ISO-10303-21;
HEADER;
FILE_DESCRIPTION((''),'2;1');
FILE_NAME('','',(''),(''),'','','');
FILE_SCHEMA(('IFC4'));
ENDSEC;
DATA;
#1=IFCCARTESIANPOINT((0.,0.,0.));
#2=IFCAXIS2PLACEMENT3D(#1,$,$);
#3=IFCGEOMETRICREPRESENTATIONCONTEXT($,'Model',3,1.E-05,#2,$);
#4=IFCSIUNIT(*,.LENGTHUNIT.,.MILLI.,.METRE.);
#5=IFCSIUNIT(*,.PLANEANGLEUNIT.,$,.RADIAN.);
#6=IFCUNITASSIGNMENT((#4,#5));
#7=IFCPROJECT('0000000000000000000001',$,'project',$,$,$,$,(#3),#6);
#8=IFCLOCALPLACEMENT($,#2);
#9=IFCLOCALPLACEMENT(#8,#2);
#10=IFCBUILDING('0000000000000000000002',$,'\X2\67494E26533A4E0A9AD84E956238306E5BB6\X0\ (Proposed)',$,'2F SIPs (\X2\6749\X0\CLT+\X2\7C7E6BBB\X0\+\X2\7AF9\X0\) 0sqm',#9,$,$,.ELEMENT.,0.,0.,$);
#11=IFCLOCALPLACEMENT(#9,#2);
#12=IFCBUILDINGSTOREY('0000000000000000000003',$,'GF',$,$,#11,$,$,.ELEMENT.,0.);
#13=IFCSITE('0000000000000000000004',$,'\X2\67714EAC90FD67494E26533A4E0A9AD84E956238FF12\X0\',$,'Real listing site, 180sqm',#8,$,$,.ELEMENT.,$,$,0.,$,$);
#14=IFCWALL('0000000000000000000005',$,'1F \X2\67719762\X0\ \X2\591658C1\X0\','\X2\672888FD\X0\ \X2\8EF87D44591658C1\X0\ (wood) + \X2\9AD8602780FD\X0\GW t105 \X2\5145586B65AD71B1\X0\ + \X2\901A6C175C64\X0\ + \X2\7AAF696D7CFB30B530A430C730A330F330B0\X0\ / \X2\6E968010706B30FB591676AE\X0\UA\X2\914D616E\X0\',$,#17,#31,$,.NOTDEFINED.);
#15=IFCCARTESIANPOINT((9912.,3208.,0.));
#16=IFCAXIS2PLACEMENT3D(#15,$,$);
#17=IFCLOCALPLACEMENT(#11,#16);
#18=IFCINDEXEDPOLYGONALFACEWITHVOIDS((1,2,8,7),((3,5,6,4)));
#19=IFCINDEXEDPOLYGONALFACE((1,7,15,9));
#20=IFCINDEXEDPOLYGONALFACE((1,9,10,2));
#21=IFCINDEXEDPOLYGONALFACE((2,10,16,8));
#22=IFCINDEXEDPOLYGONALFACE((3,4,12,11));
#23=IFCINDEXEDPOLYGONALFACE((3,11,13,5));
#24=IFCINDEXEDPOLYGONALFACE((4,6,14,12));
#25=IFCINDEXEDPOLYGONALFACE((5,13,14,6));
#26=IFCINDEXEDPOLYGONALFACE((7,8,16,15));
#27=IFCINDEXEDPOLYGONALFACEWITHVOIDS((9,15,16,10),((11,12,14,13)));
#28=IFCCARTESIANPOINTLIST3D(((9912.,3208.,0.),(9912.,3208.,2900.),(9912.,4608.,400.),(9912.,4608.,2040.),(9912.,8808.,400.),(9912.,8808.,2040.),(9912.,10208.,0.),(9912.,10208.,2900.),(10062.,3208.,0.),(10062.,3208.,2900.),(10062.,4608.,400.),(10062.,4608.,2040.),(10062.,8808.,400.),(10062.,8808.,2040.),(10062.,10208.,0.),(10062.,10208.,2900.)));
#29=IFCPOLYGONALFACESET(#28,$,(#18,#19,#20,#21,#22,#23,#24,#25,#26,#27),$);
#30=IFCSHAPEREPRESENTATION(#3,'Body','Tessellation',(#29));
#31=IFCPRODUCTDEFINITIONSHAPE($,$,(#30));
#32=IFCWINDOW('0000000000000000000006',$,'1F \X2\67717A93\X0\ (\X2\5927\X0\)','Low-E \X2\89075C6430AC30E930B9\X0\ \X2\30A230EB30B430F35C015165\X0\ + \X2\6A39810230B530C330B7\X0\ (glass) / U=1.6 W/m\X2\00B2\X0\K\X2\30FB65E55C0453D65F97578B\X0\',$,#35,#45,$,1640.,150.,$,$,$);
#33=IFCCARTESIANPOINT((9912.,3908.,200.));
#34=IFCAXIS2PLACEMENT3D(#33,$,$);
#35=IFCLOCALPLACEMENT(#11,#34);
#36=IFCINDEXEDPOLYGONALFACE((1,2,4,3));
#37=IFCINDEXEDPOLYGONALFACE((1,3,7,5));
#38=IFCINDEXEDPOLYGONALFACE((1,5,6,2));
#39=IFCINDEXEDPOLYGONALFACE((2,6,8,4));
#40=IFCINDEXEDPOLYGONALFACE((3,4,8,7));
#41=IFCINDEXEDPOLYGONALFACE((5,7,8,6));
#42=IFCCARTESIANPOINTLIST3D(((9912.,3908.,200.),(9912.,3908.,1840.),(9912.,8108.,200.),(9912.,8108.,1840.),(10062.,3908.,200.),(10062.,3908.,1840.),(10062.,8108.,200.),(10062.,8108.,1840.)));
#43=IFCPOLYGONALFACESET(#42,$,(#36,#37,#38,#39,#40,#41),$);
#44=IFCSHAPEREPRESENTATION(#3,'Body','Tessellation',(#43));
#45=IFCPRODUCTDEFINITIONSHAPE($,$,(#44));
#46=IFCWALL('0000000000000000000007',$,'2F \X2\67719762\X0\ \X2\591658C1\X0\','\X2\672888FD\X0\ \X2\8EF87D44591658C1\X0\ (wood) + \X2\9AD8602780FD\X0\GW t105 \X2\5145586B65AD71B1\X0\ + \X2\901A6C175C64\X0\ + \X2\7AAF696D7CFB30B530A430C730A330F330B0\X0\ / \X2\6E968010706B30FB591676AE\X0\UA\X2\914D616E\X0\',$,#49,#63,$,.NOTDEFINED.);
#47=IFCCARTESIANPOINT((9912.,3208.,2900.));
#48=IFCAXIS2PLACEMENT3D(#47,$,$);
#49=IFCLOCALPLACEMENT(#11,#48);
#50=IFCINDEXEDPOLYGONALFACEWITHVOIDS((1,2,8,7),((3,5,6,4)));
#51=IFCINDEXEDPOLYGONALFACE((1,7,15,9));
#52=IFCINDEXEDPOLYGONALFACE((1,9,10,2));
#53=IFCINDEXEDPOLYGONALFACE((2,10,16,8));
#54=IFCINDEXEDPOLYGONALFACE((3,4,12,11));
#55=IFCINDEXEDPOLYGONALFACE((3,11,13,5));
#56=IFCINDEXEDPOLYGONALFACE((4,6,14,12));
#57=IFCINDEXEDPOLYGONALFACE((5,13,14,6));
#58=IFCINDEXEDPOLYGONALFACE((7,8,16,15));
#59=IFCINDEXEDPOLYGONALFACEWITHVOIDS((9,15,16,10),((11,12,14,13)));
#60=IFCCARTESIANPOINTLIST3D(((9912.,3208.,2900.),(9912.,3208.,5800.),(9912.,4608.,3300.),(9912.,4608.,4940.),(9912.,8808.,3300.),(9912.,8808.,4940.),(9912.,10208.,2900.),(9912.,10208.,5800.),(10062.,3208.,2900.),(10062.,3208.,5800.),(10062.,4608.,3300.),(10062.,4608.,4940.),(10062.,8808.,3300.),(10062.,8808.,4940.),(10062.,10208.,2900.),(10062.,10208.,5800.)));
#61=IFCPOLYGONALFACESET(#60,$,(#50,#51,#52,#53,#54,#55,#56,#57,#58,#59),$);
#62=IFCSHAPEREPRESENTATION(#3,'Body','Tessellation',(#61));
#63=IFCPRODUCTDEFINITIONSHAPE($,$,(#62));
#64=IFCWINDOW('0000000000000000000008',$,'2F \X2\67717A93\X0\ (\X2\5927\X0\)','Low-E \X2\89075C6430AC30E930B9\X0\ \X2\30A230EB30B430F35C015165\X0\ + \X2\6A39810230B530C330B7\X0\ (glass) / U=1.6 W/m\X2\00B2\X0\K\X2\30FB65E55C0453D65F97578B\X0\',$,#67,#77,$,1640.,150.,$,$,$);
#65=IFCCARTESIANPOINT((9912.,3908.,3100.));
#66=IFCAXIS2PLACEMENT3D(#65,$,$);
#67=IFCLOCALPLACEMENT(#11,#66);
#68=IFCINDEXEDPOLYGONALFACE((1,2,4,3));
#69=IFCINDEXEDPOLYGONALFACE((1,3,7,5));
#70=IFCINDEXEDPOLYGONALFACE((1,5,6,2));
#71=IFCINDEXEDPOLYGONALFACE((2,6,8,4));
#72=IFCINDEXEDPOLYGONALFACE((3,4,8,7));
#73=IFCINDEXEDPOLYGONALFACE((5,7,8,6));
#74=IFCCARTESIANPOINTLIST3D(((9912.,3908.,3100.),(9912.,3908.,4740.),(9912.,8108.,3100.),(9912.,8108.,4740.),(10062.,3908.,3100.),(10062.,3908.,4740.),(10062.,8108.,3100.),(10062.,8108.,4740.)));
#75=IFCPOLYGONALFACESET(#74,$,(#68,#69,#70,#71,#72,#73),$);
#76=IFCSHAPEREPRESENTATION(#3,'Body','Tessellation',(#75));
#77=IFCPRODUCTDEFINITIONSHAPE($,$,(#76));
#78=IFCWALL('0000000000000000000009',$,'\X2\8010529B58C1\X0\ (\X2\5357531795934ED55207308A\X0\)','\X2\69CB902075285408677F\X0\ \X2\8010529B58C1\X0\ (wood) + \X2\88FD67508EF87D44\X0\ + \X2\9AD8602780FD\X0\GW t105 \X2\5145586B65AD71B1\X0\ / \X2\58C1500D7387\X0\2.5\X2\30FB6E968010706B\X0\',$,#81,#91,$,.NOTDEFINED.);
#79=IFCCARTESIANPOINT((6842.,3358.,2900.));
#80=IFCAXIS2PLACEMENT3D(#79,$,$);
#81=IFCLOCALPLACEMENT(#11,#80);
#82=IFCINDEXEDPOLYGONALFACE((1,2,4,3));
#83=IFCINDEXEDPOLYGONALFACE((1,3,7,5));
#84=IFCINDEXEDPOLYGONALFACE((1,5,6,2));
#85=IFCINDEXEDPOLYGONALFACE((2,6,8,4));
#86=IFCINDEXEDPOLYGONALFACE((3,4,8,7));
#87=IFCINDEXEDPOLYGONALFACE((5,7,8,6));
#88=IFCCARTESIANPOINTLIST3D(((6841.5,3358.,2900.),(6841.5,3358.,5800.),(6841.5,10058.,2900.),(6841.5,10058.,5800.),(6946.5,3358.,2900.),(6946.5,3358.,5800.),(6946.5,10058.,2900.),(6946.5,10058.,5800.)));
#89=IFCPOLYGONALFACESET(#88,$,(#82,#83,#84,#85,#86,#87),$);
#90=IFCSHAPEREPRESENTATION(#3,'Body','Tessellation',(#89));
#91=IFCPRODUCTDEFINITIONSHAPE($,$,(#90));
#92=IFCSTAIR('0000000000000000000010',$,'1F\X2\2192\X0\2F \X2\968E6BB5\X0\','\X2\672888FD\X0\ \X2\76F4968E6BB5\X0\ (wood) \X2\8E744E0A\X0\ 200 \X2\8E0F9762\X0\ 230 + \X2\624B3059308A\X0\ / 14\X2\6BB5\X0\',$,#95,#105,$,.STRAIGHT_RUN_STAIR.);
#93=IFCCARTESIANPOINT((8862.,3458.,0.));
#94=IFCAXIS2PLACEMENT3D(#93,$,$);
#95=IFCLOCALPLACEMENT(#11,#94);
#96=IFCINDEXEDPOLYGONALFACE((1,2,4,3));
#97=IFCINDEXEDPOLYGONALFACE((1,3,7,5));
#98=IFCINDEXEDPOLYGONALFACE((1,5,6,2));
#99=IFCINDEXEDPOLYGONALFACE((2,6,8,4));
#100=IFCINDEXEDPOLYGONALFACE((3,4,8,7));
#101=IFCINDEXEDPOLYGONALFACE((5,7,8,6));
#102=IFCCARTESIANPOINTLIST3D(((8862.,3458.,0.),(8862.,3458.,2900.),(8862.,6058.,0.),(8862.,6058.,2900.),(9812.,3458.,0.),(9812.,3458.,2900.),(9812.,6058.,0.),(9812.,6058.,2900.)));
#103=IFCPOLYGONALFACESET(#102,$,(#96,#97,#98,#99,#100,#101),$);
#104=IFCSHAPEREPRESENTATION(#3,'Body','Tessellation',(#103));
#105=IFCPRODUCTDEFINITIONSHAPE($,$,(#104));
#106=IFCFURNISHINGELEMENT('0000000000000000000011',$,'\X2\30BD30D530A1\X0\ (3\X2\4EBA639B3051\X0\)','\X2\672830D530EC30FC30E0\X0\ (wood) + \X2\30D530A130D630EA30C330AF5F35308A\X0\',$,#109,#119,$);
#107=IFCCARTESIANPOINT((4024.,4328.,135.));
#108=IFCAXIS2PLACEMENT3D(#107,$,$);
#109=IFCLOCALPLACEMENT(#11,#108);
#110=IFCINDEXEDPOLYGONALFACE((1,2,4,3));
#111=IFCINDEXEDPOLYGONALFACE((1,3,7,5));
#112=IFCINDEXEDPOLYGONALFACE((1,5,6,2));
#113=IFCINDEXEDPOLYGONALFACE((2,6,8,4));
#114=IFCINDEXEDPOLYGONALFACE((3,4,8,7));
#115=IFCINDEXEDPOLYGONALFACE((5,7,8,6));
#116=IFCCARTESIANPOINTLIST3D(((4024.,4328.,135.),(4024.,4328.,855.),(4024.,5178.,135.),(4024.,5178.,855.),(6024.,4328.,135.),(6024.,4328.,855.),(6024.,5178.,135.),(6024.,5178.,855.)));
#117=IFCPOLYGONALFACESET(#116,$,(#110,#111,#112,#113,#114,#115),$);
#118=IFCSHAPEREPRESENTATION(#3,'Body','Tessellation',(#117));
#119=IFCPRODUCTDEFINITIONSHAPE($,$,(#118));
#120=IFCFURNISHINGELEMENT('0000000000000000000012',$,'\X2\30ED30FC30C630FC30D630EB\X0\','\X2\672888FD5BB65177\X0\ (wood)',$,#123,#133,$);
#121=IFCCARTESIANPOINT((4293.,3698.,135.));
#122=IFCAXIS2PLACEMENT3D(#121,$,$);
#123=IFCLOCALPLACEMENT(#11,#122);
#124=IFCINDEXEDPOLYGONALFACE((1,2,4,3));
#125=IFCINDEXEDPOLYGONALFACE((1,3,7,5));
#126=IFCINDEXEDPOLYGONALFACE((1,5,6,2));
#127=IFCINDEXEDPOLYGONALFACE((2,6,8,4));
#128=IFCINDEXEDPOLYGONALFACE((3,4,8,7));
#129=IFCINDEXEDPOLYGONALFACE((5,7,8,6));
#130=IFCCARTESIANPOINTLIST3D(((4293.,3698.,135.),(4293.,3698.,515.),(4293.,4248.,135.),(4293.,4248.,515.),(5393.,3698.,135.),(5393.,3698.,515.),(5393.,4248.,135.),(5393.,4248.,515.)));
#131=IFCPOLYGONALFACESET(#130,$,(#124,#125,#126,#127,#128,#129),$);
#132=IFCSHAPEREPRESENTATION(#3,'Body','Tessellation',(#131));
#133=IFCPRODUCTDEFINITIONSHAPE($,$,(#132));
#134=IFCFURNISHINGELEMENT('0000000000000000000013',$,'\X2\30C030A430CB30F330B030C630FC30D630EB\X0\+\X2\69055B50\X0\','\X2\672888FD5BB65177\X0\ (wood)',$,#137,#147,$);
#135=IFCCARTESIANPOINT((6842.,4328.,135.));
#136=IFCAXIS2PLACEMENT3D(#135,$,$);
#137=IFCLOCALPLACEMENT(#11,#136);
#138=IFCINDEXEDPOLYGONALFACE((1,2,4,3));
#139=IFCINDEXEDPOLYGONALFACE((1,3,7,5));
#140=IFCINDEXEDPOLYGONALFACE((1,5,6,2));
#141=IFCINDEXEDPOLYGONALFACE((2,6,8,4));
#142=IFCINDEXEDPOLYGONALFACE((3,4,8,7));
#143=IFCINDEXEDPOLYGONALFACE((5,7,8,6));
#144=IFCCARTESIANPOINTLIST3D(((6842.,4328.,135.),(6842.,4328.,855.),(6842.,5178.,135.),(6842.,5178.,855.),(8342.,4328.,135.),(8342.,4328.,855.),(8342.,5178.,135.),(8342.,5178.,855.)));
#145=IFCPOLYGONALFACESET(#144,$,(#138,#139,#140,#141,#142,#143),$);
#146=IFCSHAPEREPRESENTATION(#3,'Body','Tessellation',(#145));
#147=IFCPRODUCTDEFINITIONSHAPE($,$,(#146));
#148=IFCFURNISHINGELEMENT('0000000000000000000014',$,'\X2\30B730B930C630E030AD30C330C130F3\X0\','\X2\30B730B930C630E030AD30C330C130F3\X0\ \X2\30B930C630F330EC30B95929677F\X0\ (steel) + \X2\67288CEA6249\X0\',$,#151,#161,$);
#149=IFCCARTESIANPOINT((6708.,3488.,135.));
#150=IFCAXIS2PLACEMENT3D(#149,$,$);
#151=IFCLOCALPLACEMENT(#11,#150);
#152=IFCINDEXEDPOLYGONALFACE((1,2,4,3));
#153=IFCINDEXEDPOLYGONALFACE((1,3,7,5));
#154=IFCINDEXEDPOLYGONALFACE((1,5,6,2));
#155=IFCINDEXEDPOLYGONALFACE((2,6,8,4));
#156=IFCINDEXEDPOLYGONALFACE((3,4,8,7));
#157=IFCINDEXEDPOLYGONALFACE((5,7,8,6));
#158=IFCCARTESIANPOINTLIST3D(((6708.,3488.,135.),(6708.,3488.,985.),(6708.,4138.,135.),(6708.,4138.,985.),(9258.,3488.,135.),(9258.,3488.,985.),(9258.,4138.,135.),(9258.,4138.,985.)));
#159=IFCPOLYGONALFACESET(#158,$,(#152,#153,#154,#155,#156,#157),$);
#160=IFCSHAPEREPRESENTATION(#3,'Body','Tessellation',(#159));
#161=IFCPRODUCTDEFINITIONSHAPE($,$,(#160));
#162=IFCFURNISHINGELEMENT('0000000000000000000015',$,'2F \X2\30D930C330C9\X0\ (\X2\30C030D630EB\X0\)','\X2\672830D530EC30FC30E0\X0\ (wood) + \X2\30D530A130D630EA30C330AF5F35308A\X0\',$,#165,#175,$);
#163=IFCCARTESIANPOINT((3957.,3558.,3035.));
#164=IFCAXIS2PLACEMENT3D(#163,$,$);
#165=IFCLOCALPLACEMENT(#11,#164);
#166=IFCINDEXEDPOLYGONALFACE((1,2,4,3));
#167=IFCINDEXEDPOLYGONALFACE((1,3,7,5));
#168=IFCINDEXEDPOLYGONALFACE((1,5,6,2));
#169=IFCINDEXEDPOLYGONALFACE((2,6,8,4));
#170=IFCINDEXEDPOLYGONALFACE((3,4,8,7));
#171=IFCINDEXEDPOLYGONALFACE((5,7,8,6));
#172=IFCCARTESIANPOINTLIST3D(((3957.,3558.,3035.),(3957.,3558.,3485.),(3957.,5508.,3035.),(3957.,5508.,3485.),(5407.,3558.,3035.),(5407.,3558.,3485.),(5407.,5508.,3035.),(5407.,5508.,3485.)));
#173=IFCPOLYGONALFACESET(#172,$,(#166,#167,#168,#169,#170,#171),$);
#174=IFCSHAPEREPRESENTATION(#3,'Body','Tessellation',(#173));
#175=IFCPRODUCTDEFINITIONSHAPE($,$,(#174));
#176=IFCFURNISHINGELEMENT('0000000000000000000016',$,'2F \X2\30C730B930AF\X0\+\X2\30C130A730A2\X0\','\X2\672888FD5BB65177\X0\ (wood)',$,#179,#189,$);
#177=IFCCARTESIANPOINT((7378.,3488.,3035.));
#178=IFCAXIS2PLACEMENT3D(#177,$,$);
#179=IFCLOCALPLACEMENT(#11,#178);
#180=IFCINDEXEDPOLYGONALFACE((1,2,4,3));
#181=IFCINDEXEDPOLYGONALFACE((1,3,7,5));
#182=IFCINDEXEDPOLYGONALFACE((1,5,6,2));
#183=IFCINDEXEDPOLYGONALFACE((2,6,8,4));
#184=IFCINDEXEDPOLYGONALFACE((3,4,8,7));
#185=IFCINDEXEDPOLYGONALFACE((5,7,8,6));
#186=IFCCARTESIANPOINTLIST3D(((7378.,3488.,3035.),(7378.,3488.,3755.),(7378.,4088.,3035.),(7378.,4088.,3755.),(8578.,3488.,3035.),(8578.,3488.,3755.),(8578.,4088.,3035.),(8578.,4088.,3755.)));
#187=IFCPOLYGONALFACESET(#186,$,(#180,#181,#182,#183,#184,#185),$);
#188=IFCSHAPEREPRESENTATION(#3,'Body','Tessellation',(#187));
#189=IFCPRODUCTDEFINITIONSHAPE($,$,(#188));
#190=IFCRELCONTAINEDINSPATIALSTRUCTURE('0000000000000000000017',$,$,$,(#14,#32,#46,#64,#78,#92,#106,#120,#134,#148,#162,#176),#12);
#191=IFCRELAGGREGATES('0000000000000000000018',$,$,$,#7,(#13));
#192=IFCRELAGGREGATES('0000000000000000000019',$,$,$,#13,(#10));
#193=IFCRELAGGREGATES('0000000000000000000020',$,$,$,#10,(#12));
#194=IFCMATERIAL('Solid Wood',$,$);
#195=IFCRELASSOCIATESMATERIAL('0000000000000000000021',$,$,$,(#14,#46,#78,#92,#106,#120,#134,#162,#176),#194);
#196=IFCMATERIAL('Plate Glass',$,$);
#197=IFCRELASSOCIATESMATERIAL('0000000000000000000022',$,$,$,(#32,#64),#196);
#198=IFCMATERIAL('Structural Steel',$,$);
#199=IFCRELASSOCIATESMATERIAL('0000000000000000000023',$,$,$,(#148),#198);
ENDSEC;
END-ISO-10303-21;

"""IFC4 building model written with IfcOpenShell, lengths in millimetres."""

from ifc_helpers import new_model, si_unit, frame, frame_2d, origin, place, context, project, spatial, rectangle, extrude, material, element, fill, save


model = new_model("IFC4")

# Units and contexts
model_context = context("Model", 3, precision=1e-05, world=origin())
ifc_project = project(units=[si_unit("LENGTHUNIT", "METRE", prefix="MILLI"), si_unit("PLANEANGLEUNIT", "RADIAN")], contexts=[model_context])

# Site, building, storey
site_placement = place(None, origin())
site = spatial("IfcSite", under=ifc_project, at=site_placement, Name="東京都杉並区上高井戸２", ObjectType="Real listing site, 180sqm", CompositionType="ELEMENT", RefElevation=0.0)
building_placement = place(site_placement, origin())
building = spatial("IfcBuilding", under=site, at=building_placement, Name="杉並区上高井戸の家 (Proposed)", ObjectType="2F SIPs (杉CLT+籾殻+竹) 0sqm", CompositionType="ELEMENT", ElevationOfRefHeight=0.0, ElevationOfTerrain=0.0)
storey_placement = place(building_placement, origin())
storey = spatial("IfcBuildingStorey", under=building, at=storey_placement, Name="GF", CompositionType="ELEMENT", Elevation=0.0)

# Wall, opening, window
ifc_material_1 = material(Name="Solid Wood")
wall_1_placement = place(storey_placement, frame((9912.0, 3208.0, 0.0)))
wall_1 = element("IfcWall", 1, at=wall_1_placement, inside=storey, material=ifc_material_1, Name="1F 東面 外壁", Description="木製 軸組外壁 (wood) + 高性能GW t105 充填断熱 + 通気層 + 窯業系サイディング / 準耐火・外皮UA配慮", PredefinedType="NOTDEFINED", context=model_context, shape_type="SweptSolid", body=[
    extrude(rectangle(XDim=150.0, YDim=7000.0, at=frame_2d((75.0, 3500.0))), frame((9912.0, 3208.0, 0.0)), (0.0, 0.0, 1.0), 2900.0),
])
opening_1_placement = place(storey_placement, frame((9912.0, 3908.0, 200.0)))
opening_1 = element("IfcOpeningElement", 2, at=opening_1_placement, cuts=wall_1, PredefinedType="NOTDEFINED", context=model_context, shape_type="SweptSolid", body=[
    extrude(rectangle(XDim=150.0, YDim=4200.0, at=frame_2d((75.0, 2100.0))), frame((9912.0, 3908.0, 200.0)), (0.0, 0.0, 1.0), 1640.0),
])
ifc_material_2 = material(Name="Plate Glass")
window_1_placement = place(storey_placement, frame((9912.0, 3908.0, 200.0)))
window_1 = element("IfcWindow", 3, at=window_1_placement, inside=storey, material=ifc_material_2, Name="1F 東窓 (大)", Description="Low-E 複層ガラス アルゴン封入 + 樹脂サッシ (glass) / U=1.6 W/m²K・日射取得型", OverallHeight=1640.0, OverallWidth=150.0, context=model_context, shape_type="SweptSolid", body=[
    extrude(rectangle(XDim=150.0, YDim=4200.0, at=frame_2d((75.0, 2100.0))), frame((9912.0, 3908.0, 200.0)), (0.0, 0.0, 1.0), 1640.0),
])
fill(opening_1, window_1)

# Wall, opening, window
wall_2_placement = place(storey_placement, frame((9912.0, 3208.0, 2900.0)))
wall_2 = element("IfcWall", 4, at=wall_2_placement, inside=storey, material=ifc_material_1, Name="2F 東面 外壁", Description="木製 軸組外壁 (wood) + 高性能GW t105 充填断熱 + 通気層 + 窯業系サイディング / 準耐火・外皮UA配慮", PredefinedType="NOTDEFINED", context=model_context, shape_type="SweptSolid", body=[
    extrude(rectangle(XDim=150.0, YDim=7000.0, at=frame_2d((75.0, 3500.0))), frame((9912.0, 3208.0, 2900.0)), (0.0, 0.0, 1.0), 2900.0),
])
opening_2_placement = place(storey_placement, frame((9912.0, 3908.0, 3100.0)))
opening_2 = element("IfcOpeningElement", 5, at=opening_2_placement, cuts=wall_2, PredefinedType="NOTDEFINED", context=model_context, shape_type="SweptSolid", body=[
    extrude(rectangle(XDim=150.0, YDim=4200.0, at=frame_2d((75.0, 2100.0))), frame((9912.0, 3908.0, 3100.0)), (0.0, 0.0, 1.0), 1640.0),
])
window_2_placement = place(storey_placement, frame((9912.0, 3908.0, 3100.0)))
window_2 = element("IfcWindow", 6, at=window_2_placement, inside=storey, material=ifc_material_2, Name="2F 東窓 (大)", Description="Low-E 複層ガラス アルゴン封入 + 樹脂サッシ (glass) / U=1.6 W/m²K・日射取得型", OverallHeight=1640.0, OverallWidth=150.0, context=model_context, shape_type="SweptSolid", body=[
    extrude(rectangle(XDim=150.0, YDim=4200.0, at=frame_2d((75.0, 2100.0))), frame((9912.0, 3908.0, 3100.0)), (0.0, 0.0, 1.0), 1640.0),
])
fill(opening_2, window_2)

# Wall
wall_3_placement = place(storey_placement, frame((6842.0, 3358.0, 2900.0)))
element("IfcWall", 7, at=wall_3_placement, inside=storey, material=ifc_material_1, Name="耐力壁 (南北間仕切り)", Description="構造用合板 耐力壁 (wood) + 製材軸組 + 高性能GW t105 充填断熱 / 壁倍率2.5・準耐火", PredefinedType="NOTDEFINED", context=model_context, shape_type="SweptSolid", body=[
    extrude(rectangle(XDim=105.0, YDim=6700.0, at=frame_2d((52.0, 3350.0))), frame((6842.0, 3358.0, 2900.0)), (0.0, 0.0, 1.0), 2900.0),
])

# Stair
stair_placement = place(storey_placement, frame((8862.0, 3458.0, 0.0)))
element("IfcStair", 8, at=stair_placement, inside=storey, material=ifc_material_1, Name="1F→2F 階段", Description="木製 直階段 (wood) 蹴上 200 踏面 230 + 手すり / 14段", PredefinedType="STRAIGHT_RUN_STAIR", context=model_context, shape_type="SweptSolid", body=[
    extrude(rectangle(XDim=950.0, YDim=2600.0, at=frame_2d((475.0, 1300.0))), frame((8862.0, 3458.0, 0.0)), (0.0, 0.0, 1.0), 2900.0),
])

# Furnishing elements
furnishing_1_placement = place(storey_placement, frame((4024.0, 4328.0, 135.0)))
element("IfcFurnishingElement", 9, at=furnishing_1_placement, inside=storey, material=ifc_material_1, Name="ソファ (3人掛け)", Description="木フレーム (wood) + ファブリック張り", context=model_context, shape_type="SweptSolid", body=[
    extrude(rectangle(XDim=2000.0, YDim=850.0, at=frame_2d((1000.0, 425.0))), frame((4024.0, 4328.0, 135.0)), (0.0, 0.0, 1.0), 720.0),
])
furnishing_2_placement = place(storey_placement, frame((4293.0, 3698.0, 135.0)))
element("IfcFurnishingElement", 10, at=furnishing_2_placement, inside=storey, material=ifc_material_1, Name="ローテーブル", Description="木製家具 (wood)", context=model_context, shape_type="SweptSolid", body=[
    extrude(rectangle(XDim=1100.0, YDim=550.0, at=frame_2d((550.0, 275.0))), frame((4293.0, 3698.0, 135.0)), (0.0, 0.0, 1.0), 380.0),
])
furnishing_3_placement = place(storey_placement, frame((6842.0, 4328.0, 135.0)))
element("IfcFurnishingElement", 11, at=furnishing_3_placement, inside=storey, material=ifc_material_1, Name="ダイニングテーブル+椅子", Description="木製家具 (wood)", context=model_context, shape_type="SweptSolid", body=[
    extrude(rectangle(XDim=1500.0, YDim=850.0, at=frame_2d((750.0, 425.0))), frame((6842.0, 4328.0, 135.0)), (0.0, 0.0, 1.0), 720.0),
])
ifc_material_3 = material(Name="Structural Steel")
furnishing_4_placement = place(storey_placement, frame((6708.0, 3488.0, 135.0)))
element("IfcFurnishingElement", 12, at=furnishing_4_placement, inside=storey, material=ifc_material_3, Name="システムキッチン", Description="システムキッチン ステンレス天板 (steel) + 木質扉", context=model_context, shape_type="SweptSolid", body=[
    extrude(rectangle(XDim=2550.0, YDim=650.0, at=frame_2d((1275.0, 325.0))), frame((6708.0, 3488.0, 135.0)), (0.0, 0.0, 1.0), 850.0),
])
furnishing_5_placement = place(storey_placement, frame((3957.0, 3558.0, 3035.0)))
element("IfcFurnishingElement", 13, at=furnishing_5_placement, inside=storey, material=ifc_material_1, Name="2F ベッド (ダブル)", Description="木フレーム (wood) + ファブリック張り", context=model_context, shape_type="SweptSolid", body=[
    extrude(rectangle(XDim=1450.0, YDim=1950.0, at=frame_2d((725.0, 975.0))), frame((3957.0, 3558.0, 3035.0)), (0.0, 0.0, 1.0), 450.0),
])
furnishing_6_placement = place(storey_placement, frame((7378.0, 3488.0, 3035.0)))
element("IfcFurnishingElement", 14, at=furnishing_6_placement, inside=storey, material=ifc_material_1, Name="2F デスク+チェア", Description="木製家具 (wood)", context=model_context, shape_type="SweptSolid", body=[
    extrude(rectangle(XDim=1200.0, YDim=600.0, at=frame_2d((600.0, 300.0))), frame((7378.0, 3488.0, 3035.0)), (0.0, 0.0, 1.0), 720.0),
])

save(model, "model.ifc")
